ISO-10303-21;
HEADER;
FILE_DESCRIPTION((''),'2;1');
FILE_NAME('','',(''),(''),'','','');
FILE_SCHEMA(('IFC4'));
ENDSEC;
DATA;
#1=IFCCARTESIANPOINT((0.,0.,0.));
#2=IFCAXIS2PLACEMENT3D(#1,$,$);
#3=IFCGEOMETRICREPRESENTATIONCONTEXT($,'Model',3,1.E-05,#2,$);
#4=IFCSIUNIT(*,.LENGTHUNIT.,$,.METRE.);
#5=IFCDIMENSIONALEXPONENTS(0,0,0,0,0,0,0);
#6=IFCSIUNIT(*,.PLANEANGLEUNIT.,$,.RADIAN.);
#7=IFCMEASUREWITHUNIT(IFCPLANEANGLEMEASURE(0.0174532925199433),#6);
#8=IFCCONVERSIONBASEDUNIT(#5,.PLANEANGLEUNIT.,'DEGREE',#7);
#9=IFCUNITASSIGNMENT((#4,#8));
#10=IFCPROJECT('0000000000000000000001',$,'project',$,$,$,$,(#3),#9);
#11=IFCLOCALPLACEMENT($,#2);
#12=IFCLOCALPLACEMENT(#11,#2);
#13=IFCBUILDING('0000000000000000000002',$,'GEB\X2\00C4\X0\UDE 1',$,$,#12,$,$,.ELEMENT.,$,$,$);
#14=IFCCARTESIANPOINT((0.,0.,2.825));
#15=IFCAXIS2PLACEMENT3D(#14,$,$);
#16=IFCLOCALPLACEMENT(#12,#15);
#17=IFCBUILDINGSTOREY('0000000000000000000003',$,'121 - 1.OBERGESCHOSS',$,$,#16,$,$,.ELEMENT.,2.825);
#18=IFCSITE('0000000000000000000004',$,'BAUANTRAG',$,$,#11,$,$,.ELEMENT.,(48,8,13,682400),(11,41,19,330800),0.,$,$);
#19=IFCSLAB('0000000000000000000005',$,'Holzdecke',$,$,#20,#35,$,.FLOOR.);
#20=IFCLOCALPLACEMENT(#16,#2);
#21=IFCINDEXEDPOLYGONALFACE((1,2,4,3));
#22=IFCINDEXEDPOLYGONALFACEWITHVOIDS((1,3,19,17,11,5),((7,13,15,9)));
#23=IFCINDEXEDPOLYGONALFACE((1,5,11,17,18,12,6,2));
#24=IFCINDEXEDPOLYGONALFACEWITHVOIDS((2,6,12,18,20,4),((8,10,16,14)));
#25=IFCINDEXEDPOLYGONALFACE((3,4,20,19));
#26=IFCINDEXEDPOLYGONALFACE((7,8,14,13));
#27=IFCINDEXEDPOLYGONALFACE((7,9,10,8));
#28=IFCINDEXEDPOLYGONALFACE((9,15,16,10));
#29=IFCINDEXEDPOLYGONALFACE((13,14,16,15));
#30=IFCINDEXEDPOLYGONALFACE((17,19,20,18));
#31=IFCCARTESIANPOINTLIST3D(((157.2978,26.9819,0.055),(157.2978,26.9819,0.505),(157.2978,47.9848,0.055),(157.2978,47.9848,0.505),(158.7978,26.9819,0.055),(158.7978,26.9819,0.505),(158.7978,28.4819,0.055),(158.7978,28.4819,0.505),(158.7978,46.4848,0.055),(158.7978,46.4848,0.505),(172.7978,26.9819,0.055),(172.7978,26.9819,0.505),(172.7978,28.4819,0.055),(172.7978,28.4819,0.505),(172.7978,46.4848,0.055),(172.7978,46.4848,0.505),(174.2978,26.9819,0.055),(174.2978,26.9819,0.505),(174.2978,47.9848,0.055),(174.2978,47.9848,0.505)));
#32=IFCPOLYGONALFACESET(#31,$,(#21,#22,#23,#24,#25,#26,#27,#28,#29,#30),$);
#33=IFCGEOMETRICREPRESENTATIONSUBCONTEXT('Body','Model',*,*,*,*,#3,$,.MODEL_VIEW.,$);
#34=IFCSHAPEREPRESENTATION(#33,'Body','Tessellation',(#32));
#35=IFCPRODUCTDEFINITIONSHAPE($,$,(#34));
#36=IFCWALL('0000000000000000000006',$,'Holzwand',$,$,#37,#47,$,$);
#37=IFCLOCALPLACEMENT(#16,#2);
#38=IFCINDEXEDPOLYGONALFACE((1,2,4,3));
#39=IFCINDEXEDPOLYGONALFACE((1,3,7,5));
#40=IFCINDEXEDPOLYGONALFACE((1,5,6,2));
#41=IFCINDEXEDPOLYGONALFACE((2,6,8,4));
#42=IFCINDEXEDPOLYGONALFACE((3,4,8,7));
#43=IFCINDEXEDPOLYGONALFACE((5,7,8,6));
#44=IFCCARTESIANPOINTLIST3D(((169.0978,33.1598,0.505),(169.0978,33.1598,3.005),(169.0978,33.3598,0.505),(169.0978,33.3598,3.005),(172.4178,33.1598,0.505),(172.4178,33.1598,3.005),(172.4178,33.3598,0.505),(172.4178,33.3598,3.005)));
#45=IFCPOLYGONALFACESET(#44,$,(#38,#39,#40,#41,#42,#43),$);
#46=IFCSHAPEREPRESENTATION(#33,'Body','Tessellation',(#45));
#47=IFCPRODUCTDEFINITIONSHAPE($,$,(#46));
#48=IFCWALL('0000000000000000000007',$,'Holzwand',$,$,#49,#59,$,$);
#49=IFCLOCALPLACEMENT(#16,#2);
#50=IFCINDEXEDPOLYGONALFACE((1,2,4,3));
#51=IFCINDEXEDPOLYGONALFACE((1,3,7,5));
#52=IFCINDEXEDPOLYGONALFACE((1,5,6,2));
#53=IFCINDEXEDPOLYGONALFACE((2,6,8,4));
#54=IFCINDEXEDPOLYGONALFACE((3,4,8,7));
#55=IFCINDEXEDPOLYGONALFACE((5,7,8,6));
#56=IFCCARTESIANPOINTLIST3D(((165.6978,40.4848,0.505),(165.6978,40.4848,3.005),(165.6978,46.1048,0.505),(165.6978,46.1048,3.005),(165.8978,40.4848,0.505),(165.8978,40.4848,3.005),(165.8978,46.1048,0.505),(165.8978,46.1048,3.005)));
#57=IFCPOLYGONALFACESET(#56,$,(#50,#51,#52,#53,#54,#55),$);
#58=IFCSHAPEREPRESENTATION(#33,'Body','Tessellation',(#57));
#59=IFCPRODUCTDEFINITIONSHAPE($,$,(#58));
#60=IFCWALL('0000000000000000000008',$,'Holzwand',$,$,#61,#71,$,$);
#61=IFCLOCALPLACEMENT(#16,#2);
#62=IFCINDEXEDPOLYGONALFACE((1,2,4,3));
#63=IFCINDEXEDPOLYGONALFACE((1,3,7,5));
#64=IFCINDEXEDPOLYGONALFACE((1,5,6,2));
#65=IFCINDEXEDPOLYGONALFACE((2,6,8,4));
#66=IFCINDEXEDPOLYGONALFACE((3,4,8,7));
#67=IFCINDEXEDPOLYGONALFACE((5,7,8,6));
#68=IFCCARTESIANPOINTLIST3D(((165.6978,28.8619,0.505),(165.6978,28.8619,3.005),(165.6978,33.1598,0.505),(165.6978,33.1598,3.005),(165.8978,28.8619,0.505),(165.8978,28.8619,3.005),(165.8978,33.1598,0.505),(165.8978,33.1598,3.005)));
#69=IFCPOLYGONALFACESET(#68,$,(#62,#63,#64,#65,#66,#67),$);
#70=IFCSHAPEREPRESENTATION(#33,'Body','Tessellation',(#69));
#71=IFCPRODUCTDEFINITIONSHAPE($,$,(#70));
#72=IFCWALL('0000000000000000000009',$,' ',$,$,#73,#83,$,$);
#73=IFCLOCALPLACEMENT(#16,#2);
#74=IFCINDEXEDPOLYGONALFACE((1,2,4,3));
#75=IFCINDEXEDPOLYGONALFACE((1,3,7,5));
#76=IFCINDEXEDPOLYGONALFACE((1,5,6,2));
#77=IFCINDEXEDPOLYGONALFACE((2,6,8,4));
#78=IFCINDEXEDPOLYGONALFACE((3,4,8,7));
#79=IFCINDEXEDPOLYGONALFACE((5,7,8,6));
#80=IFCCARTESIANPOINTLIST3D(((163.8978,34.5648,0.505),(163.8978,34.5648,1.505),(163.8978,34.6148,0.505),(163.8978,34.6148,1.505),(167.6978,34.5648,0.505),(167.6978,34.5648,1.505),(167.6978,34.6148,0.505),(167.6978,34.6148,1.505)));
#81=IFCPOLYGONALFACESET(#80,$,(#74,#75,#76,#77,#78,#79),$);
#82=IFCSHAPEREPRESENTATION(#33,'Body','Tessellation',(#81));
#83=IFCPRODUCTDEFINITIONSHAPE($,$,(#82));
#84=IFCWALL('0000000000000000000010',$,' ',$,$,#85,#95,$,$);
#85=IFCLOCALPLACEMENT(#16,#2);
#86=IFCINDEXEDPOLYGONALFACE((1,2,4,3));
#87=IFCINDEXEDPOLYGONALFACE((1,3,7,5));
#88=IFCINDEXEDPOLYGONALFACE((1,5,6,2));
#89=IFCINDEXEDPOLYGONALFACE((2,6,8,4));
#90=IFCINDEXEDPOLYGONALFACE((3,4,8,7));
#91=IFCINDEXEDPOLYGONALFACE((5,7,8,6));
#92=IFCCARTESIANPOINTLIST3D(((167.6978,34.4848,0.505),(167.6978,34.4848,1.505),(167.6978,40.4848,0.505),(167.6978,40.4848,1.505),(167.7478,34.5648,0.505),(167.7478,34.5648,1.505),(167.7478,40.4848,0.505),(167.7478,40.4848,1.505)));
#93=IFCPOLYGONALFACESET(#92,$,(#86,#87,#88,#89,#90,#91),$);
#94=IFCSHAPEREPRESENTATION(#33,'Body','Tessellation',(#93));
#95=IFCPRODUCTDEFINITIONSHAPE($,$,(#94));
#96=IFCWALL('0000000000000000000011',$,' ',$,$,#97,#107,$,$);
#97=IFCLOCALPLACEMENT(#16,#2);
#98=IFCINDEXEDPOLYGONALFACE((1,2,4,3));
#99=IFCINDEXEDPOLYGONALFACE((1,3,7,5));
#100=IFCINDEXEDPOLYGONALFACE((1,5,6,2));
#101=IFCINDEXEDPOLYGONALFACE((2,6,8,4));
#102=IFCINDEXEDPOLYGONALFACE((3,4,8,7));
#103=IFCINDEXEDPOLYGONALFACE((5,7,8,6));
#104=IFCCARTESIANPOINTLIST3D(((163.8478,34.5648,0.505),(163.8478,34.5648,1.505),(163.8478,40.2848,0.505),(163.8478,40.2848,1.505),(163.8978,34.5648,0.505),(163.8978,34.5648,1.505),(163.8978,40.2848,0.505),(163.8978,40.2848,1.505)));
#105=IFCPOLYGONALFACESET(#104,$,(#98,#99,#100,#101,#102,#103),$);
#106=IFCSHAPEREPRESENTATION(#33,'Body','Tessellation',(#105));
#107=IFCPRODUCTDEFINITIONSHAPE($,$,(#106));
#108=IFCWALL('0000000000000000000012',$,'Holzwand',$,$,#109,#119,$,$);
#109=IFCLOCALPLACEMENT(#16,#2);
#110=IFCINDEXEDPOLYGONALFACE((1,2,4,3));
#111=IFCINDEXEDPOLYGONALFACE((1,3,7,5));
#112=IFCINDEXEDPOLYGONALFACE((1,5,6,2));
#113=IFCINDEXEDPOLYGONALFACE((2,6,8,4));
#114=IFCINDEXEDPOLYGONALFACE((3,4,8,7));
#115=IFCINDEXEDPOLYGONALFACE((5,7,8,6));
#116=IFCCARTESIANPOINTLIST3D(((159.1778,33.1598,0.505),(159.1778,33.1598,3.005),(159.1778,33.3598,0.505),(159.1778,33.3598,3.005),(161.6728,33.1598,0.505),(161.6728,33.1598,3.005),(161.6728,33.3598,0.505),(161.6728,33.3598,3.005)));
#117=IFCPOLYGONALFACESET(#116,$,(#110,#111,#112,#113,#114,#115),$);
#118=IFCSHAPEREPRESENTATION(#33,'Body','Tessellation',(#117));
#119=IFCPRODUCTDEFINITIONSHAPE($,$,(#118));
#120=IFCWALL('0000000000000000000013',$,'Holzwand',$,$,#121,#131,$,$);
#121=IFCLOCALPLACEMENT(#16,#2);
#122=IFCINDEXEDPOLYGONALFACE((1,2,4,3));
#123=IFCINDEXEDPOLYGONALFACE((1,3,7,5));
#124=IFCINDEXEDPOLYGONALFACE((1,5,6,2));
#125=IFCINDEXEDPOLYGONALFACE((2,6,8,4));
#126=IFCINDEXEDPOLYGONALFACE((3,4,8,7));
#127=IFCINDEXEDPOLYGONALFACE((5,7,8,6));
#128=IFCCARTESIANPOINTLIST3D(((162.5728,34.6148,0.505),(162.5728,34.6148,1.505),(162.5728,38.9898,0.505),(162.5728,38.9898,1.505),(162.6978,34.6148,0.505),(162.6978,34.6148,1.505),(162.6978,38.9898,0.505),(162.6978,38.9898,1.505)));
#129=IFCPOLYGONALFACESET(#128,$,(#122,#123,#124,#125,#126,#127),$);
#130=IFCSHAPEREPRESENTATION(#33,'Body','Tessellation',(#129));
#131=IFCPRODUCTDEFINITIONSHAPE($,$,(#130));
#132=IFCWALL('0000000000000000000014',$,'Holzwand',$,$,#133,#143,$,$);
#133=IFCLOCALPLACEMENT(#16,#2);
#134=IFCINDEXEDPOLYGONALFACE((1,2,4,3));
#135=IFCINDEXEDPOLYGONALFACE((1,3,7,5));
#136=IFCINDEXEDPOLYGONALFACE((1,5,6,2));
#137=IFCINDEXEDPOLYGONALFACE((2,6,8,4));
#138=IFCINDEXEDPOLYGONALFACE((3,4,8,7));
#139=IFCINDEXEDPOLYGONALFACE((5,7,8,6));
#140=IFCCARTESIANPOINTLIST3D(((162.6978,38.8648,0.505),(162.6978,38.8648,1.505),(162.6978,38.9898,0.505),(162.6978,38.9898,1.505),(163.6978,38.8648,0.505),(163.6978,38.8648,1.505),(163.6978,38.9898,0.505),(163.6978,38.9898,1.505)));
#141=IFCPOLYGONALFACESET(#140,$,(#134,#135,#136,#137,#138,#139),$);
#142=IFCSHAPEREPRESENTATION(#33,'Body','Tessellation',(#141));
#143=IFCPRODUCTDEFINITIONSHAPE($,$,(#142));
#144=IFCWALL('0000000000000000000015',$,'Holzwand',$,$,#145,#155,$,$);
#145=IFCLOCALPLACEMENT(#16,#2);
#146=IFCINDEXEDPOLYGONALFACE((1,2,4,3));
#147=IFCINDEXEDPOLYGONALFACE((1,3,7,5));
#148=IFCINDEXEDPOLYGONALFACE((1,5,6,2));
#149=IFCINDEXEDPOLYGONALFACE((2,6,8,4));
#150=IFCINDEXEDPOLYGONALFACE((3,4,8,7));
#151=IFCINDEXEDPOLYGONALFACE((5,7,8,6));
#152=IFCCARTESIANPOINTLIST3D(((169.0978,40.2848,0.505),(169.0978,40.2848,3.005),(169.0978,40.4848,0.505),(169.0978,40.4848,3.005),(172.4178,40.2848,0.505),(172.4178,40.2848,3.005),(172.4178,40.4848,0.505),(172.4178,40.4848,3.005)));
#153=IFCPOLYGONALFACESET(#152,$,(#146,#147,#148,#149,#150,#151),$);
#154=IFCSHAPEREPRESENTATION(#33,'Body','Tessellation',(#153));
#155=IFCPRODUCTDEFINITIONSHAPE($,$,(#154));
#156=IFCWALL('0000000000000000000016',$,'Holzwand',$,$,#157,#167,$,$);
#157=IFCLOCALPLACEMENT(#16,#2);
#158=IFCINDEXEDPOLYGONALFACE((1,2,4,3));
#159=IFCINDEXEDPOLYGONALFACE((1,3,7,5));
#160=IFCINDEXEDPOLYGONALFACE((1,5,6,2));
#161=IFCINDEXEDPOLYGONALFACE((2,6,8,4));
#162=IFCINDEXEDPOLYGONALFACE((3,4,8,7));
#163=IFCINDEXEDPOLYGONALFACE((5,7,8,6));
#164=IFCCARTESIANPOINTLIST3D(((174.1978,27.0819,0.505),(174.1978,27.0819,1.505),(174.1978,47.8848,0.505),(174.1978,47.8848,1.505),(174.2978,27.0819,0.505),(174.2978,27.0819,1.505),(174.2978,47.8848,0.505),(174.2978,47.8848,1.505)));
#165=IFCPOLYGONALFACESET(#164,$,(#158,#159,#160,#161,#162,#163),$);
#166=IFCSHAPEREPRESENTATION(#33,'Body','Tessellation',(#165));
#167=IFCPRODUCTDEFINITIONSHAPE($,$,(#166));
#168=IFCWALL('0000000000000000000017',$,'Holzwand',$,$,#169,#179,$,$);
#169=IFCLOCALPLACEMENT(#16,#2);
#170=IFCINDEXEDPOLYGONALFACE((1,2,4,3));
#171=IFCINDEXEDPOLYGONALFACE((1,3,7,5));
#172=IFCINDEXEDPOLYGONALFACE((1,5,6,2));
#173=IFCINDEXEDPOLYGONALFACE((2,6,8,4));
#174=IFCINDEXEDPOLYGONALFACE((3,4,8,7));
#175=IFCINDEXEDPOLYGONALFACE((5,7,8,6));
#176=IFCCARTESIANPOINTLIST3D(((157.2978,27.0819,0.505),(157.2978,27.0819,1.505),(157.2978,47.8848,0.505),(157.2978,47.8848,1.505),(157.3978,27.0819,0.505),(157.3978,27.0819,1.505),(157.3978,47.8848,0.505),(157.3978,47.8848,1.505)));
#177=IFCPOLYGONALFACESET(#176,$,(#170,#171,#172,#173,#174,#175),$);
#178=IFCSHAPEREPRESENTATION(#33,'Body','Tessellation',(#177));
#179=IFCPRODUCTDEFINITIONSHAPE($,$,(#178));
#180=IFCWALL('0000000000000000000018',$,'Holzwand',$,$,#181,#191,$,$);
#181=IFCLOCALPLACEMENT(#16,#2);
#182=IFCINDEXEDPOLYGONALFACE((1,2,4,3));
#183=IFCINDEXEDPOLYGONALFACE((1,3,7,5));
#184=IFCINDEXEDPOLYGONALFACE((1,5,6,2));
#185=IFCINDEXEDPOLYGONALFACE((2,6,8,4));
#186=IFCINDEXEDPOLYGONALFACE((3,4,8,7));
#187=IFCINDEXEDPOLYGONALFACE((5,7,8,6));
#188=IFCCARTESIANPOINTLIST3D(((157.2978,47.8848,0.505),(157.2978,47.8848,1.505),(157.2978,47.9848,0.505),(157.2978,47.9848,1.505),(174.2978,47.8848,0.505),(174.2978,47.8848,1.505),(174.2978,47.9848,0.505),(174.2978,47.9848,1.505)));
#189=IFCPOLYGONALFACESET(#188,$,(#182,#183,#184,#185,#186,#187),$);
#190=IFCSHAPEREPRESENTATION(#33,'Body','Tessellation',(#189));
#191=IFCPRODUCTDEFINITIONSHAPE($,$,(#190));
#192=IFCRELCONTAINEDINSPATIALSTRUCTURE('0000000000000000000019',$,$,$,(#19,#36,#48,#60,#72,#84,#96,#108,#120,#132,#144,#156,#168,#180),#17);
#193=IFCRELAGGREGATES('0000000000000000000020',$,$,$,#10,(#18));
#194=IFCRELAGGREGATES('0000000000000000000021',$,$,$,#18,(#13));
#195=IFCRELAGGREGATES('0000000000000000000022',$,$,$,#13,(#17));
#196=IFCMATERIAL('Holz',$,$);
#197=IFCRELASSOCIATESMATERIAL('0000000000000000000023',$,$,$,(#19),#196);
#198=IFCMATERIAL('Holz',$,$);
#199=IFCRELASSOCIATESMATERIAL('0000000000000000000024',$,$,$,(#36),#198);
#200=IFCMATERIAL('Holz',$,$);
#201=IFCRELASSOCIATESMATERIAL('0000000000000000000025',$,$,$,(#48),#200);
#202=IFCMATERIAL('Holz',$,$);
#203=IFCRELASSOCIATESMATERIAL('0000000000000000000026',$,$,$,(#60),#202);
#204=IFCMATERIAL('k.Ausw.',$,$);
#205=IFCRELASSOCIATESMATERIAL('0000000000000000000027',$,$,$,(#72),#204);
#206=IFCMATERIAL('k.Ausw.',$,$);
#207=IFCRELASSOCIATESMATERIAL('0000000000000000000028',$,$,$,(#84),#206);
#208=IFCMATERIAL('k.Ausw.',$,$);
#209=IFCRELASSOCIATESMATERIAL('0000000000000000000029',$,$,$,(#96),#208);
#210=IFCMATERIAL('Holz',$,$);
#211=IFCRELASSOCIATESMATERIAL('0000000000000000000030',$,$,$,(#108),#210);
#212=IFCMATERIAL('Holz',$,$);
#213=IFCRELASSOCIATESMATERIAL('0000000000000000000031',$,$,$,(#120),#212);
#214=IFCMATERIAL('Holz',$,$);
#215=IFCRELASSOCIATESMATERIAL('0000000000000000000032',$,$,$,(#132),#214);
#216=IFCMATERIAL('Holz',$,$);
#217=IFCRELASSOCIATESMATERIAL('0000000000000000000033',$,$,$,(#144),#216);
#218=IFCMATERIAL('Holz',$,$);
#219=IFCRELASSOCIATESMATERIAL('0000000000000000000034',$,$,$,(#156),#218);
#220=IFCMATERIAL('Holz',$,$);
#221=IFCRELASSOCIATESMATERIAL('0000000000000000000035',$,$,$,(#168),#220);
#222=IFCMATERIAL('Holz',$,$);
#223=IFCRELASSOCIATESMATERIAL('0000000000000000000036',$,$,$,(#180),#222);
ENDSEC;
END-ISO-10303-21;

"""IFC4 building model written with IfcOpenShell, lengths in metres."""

from ifc_helpers import new_model, entity, si_unit, converted_unit, frame, origin, origin_with_axes, place, context, subcontext, project, spatial, indexed_curve, outline, extrude, material, element, save


model = new_model("IFC4")

# Units and contexts
model_context = context("Model", 3, precision=1e-05, world=origin())
body_context = subcontext(model_context, "Body", "Model", "MODEL_VIEW")
ifc_project = project(units=[si_unit("LENGTHUNIT", "METRE"), converted_unit("PLANEANGLEUNIT", "DEGREE", entity("IfcPlaneAngleMeasure", 0.0174532925199433), si_unit("PLANEANGLEUNIT", "RADIAN"), dimensions=[0, 0, 0, 0, 0, 0, 0])], contexts=[model_context])

# Site, building, storey
site_placement = place(None, origin())
site = spatial("IfcSite", under=ifc_project, at=site_placement, Name="BAUANTRAG", CompositionType="ELEMENT", RefLatitude=(48, 8, 13, 682400), RefLongitude=(11, 41, 19, 330800), RefElevation=0.0)
building_placement = place(site_placement, origin())
building = spatial("IfcBuilding", under=site, at=building_placement, Name="GEBÄUDE 1", CompositionType="ELEMENT")
storey_placement = place(building_placement, frame((0.0, 0.0, 2.825)))
storey = spatial("IfcBuildingStorey", under=building, at=storey_placement, Name="121 - 1.OBERGESCHOSS", CompositionType="ELEMENT", Elevation=2.825)

# Slab
ifc_material_1 = material(Name="Holz")
slab_placement = place(storey_placement, frame((157.2978, 26.9819, 0.055)))
element("IfcSlab", 1, at=slab_placement, inside=storey, material=ifc_material_1, Name="Holzdecke", PredefinedType="FLOOR", context=body_context, shape_type="SweptSolid", body=[
    extrude(outline(indexed_curve([(17.0, 0.0), (17.0, 21.0029), (0.0, 21.0029), (0.0, 0.0), (1.5, 0.0), (15.5, 0.0), (17.0, 0.0)], self_intersect=False), holes=[indexed_curve([(15.5, 19.5029), (15.5, 1.5), (1.5, 1.5), (1.5, 19.5029), (15.5, 19.5029)], self_intersect=False)]), origin_with_axes(), (0.0, 0.0, 1.0), 0.45),
])

# Walls
ifc_material_2 = material(Name="Holz")
wall_1_placement = place(storey_placement, frame((169.0978, 33.1598, 0.505)))
element("IfcWall", 2, at=wall_1_placement, inside=storey, material=ifc_material_2, Name="Holzwand", context=body_context, shape_type="SweptSolid", body=[
    extrude(outline(indexed_curve([(0.0, 0.0), (3.32, 0.0), (3.32, 0.2), (0.0, 0.2), (0.0, 0.0)], self_intersect=False)), origin_with_axes(), (0.0, 0.0, 1.0), 2.5),
])
ifc_material_3 = material(Name="Holz")
wall_2_placement = place(storey_placement, frame((165.6978, 46.1048, 0.505), z_axis=(0.0, 0.0, 1.0), x_axis=(0.0, -1.0, 0.0)))
element("IfcWall", 3, at=wall_2_placement, inside=storey, material=ifc_material_3, Name="Holzwand", context=body_context, shape_type="SweptSolid", body=[
    extrude(outline(indexed_curve([(-5.62, 0.0), (0.0, 0.0), (0.0, 0.2), (-5.62, 0.2), (-5.62, 0.0)], self_intersect=False)), frame((5.62, 0.0, 0.0), z_axis=(0.0, 0.0, 1.0), x_axis=(1.0, 0.0, 0.0)), (0.0, 0.0, 1.0), 2.5),
])
ifc_material_4 = material(Name="Holz")
wall_3_placement = place(storey_placement, frame((165.6978, 33.1598, 0.505), z_axis=(0.0, 0.0, 1.0), x_axis=(0.0, -1.0, 0.0)))
element("IfcWall", 4, at=wall_3_placement, inside=storey, material=ifc_material_4, Name="Holzwand", context=body_context, shape_type="SweptSolid", body=[
    extrude(outline(indexed_curve([(-4.2979, 0.0), (0.0, 0.0), (0.0, 0.2), (-4.2979, 0.2), (-4.2979, 0.0)], self_intersect=False)), frame((4.2979, 0.0, 0.0), z_axis=(0.0, 0.0, 1.0), x_axis=(1.0, 0.0, 0.0)), (0.0, 0.0, 1.0), 2.5),
])
ifc_material_5 = material(Name="k.Ausw.")
wall_4_placement = place(storey_placement, frame((163.8978, 34.5648, 0.505), z_axis=(0.0, 0.0, 1.0), x_axis=(1.0, 0.0, 0.0)))
element("IfcWall", 5, at=wall_4_placement, inside=storey, material=ifc_material_5, Name=" ", context=body_context, shape_type="SweptSolid", body=[
    extrude(outline(indexed_curve([(0.0, 0.0), (3.8, 0.0), (3.8, 0.05), (0.0, 0.05), (0.0, 0.0)], self_intersect=False)), origin_with_axes(), (0.0, 0.0, 1.0), 1.0),
])
ifc_material_6 = material(Name="k.Ausw.")
wall_5_placement = place(storey_placement, frame((167.7478, 34.5648, 0.505), z_axis=(0.0, 0.0, 1.0), x_axis=(0.0, 1.0, 0.0)))
element("IfcWall", 6, at=wall_5_placement, inside=storey, material=ifc_material_6, Name=" ", context=body_context, shape_type="SweptSolid", body=[
    extrude(outline(indexed_curve([(0.08, -0.05), (6.0, -0.05), (6.0, 0.0), (0.0, 0.0), (0.08, -0.05)], self_intersect=False)), frame((-0.08, 0.05, 0.0), z_axis=(0.0, 0.0, 1.0), x_axis=(1.0, 0.0, 0.0)), (0.0, 0.0, 1.0), 1.0),
])
ifc_material_7 = material(Name="k.Ausw.")
wall_6_placement = place(storey_placement, frame((163.8478, 40.2848, 0.505), z_axis=(0.0, 0.0, 1.0), x_axis=(0.0, -1.0, 0.0)))
element("IfcWall", 7, at=wall_6_placement, inside=storey, material=ifc_material_7, Name=" ", context=body_context, shape_type="SweptSolid", body=[
    extrude(outline(indexed_curve([(-5.72, 0.0), (0.0, 0.0), (0.0, 0.05), (-5.72, 0.05), (-5.72, 0.0)], self_intersect=False)), frame((5.72, 0.0, 0.0), z_axis=(0.0, 0.0, 1.0), x_axis=(1.0, 0.0, 0.0)), (0.0, 0.0, 1.0), 1.0),
])
ifc_material_8 = material(Name="Holz")
wall_7_placement = place(storey_placement, frame((159.1778, 33.1598, 0.505)))
element("IfcWall", 8, at=wall_7_placement, inside=storey, material=ifc_material_8, Name="Holzwand", context=body_context, shape_type="SweptSolid", body=[
    extrude(outline(indexed_curve([(0.0, 0.0), (2.495, 0.0), (2.495, 0.2), (0.0, 0.2), (0.0, 0.0)], self_intersect=False)), origin_with_axes(), (0.0, 0.0, 1.0), 2.5),
])
ifc_material_9 = material(Name="Holz")
wall_8_placement = place(storey_placement, frame((162.6978, 34.6148, 0.505), z_axis=(0.0, 0.0, 1.0), x_axis=(0.0, 1.0, 0.0)))
element("IfcWall", 9, at=wall_8_placement, inside=storey, material=ifc_material_9, Name="Holzwand", context=body_context, shape_type="SweptSolid", body=[
    extrude(outline(indexed_curve([(0.0, -0.125), (4.375, -0.125), (4.375, 0.0), (0.0, 0.0), (0.0, -0.125)], self_intersect=False)), frame((0.0, 0.125, 0.0), z_axis=(0.0, 0.0, 1.0), x_axis=(1.0, 0.0, 0.0)), (0.0, 0.0, 1.0), 1.0),
])
ifc_material_10 = material(Name="Holz")
wall_9_placement = place(storey_placement, frame((162.6978, 38.8648, 0.505)))
element("IfcWall", 10, at=wall_9_placement, inside=storey, material=ifc_material_10, Name="Holzwand", context=body_context, shape_type="SweptSolid", body=[
    extrude(outline(indexed_curve([(0.0, 0.0), (1.0, 0.0), (1.0, 0.125), (0.0, 0.125), (0.0, 0.0)], self_intersect=False)), origin_with_axes(), (0.0, 0.0, 1.0), 1.0),
])
ifc_material_11 = material(Name="Holz")
wall_10_placement = place(storey_placement, frame((172.4178, 40.4848, 0.505), z_axis=(0.0, 0.0, 1.0), x_axis=(-1.0, 0.0, 0.0)))
element("IfcWall", 11, at=wall_10_placement, inside=storey, material=ifc_material_11, Name="Holzwand", context=body_context, shape_type="SweptSolid", body=[
    extrude(outline(indexed_curve([(-3.32, -0.2), (0.0, -0.2), (0.0, 0.0), (-3.32, 0.0), (-3.32, -0.2)], self_intersect=False)), frame((3.32, 0.2, 0.0), z_axis=(0.0, 0.0, 1.0), x_axis=(1.0, 0.0, 0.0)), (0.0, 0.0, 1.0), 2.5),
])
ifc_material_12 = material(Name="Holz")
wall_11_placement = place(storey_placement, frame((174.2978, 27.0819, 0.505), z_axis=(0.0, 0.0, 1.0), x_axis=(0.0, 1.0, 0.0)))
element("IfcWall", 12, at=wall_11_placement, inside=storey, material=ifc_material_12, Name="Holzwand", context=body_context, shape_type="SweptSolid", body=[
    extrude(outline(indexed_curve([(0.0, -0.1), (20.8029, -0.1), (20.8029, 0.0), (0.0, 0.0), (0.0, -0.1)], self_intersect=False)), frame((0.0, 0.1, 0.0), z_axis=(0.0, 0.0, 1.0), x_axis=(1.0, 0.0, 0.0)), (0.0, 0.0, 1.0), 1.0),
])
ifc_material_13 = material(Name="Holz")
wall_12_placement = place(storey_placement, frame((157.2978, 47.8848, 0.505), z_axis=(0.0, 0.0, 1.0), x_axis=(0.0, -1.0, 0.0)))
element("IfcWall", 13, at=wall_12_placement, inside=storey, material=ifc_material_13, Name="Holzwand", context=body_context, shape_type="SweptSolid", body=[
    extrude(outline(indexed_curve([(-20.8029, 0.0), (0.0, 0.0), (0.0, 0.1), (-20.8029, 0.1), (-20.8029, 0.0)], self_intersect=False)), frame((20.8029, 0.0, 0.0), z_axis=(0.0, 0.0, 1.0), x_axis=(1.0, 0.0, 0.0)), (0.0, 0.0, 1.0), 1.0),
])
ifc_material_14 = material(Name="Holz")
wall_13_placement = place(storey_placement, frame((174.2978, 47.9848, 0.505), z_axis=(0.0, 0.0, 1.0), x_axis=(-1.0, 0.0, 0.0)))
element("IfcWall", 14, at=wall_13_placement, inside=storey, material=ifc_material_14, Name="Holzwand", context=body_context, shape_type="SweptSolid", body=[
    extrude(outline(indexed_curve([(-17.0, -0.1), (0.0, -0.1), (0.0, 0.0), (-17.0, 0.0), (-17.0, -0.1)], self_intersect=False)), frame((17.0, 0.1, 0.0), z_axis=(0.0, 0.0, 1.0), x_axis=(1.0, 0.0, 0.0)), (0.0, 0.0, 1.0), 1.0),
])

save(model, "model.ifc")
